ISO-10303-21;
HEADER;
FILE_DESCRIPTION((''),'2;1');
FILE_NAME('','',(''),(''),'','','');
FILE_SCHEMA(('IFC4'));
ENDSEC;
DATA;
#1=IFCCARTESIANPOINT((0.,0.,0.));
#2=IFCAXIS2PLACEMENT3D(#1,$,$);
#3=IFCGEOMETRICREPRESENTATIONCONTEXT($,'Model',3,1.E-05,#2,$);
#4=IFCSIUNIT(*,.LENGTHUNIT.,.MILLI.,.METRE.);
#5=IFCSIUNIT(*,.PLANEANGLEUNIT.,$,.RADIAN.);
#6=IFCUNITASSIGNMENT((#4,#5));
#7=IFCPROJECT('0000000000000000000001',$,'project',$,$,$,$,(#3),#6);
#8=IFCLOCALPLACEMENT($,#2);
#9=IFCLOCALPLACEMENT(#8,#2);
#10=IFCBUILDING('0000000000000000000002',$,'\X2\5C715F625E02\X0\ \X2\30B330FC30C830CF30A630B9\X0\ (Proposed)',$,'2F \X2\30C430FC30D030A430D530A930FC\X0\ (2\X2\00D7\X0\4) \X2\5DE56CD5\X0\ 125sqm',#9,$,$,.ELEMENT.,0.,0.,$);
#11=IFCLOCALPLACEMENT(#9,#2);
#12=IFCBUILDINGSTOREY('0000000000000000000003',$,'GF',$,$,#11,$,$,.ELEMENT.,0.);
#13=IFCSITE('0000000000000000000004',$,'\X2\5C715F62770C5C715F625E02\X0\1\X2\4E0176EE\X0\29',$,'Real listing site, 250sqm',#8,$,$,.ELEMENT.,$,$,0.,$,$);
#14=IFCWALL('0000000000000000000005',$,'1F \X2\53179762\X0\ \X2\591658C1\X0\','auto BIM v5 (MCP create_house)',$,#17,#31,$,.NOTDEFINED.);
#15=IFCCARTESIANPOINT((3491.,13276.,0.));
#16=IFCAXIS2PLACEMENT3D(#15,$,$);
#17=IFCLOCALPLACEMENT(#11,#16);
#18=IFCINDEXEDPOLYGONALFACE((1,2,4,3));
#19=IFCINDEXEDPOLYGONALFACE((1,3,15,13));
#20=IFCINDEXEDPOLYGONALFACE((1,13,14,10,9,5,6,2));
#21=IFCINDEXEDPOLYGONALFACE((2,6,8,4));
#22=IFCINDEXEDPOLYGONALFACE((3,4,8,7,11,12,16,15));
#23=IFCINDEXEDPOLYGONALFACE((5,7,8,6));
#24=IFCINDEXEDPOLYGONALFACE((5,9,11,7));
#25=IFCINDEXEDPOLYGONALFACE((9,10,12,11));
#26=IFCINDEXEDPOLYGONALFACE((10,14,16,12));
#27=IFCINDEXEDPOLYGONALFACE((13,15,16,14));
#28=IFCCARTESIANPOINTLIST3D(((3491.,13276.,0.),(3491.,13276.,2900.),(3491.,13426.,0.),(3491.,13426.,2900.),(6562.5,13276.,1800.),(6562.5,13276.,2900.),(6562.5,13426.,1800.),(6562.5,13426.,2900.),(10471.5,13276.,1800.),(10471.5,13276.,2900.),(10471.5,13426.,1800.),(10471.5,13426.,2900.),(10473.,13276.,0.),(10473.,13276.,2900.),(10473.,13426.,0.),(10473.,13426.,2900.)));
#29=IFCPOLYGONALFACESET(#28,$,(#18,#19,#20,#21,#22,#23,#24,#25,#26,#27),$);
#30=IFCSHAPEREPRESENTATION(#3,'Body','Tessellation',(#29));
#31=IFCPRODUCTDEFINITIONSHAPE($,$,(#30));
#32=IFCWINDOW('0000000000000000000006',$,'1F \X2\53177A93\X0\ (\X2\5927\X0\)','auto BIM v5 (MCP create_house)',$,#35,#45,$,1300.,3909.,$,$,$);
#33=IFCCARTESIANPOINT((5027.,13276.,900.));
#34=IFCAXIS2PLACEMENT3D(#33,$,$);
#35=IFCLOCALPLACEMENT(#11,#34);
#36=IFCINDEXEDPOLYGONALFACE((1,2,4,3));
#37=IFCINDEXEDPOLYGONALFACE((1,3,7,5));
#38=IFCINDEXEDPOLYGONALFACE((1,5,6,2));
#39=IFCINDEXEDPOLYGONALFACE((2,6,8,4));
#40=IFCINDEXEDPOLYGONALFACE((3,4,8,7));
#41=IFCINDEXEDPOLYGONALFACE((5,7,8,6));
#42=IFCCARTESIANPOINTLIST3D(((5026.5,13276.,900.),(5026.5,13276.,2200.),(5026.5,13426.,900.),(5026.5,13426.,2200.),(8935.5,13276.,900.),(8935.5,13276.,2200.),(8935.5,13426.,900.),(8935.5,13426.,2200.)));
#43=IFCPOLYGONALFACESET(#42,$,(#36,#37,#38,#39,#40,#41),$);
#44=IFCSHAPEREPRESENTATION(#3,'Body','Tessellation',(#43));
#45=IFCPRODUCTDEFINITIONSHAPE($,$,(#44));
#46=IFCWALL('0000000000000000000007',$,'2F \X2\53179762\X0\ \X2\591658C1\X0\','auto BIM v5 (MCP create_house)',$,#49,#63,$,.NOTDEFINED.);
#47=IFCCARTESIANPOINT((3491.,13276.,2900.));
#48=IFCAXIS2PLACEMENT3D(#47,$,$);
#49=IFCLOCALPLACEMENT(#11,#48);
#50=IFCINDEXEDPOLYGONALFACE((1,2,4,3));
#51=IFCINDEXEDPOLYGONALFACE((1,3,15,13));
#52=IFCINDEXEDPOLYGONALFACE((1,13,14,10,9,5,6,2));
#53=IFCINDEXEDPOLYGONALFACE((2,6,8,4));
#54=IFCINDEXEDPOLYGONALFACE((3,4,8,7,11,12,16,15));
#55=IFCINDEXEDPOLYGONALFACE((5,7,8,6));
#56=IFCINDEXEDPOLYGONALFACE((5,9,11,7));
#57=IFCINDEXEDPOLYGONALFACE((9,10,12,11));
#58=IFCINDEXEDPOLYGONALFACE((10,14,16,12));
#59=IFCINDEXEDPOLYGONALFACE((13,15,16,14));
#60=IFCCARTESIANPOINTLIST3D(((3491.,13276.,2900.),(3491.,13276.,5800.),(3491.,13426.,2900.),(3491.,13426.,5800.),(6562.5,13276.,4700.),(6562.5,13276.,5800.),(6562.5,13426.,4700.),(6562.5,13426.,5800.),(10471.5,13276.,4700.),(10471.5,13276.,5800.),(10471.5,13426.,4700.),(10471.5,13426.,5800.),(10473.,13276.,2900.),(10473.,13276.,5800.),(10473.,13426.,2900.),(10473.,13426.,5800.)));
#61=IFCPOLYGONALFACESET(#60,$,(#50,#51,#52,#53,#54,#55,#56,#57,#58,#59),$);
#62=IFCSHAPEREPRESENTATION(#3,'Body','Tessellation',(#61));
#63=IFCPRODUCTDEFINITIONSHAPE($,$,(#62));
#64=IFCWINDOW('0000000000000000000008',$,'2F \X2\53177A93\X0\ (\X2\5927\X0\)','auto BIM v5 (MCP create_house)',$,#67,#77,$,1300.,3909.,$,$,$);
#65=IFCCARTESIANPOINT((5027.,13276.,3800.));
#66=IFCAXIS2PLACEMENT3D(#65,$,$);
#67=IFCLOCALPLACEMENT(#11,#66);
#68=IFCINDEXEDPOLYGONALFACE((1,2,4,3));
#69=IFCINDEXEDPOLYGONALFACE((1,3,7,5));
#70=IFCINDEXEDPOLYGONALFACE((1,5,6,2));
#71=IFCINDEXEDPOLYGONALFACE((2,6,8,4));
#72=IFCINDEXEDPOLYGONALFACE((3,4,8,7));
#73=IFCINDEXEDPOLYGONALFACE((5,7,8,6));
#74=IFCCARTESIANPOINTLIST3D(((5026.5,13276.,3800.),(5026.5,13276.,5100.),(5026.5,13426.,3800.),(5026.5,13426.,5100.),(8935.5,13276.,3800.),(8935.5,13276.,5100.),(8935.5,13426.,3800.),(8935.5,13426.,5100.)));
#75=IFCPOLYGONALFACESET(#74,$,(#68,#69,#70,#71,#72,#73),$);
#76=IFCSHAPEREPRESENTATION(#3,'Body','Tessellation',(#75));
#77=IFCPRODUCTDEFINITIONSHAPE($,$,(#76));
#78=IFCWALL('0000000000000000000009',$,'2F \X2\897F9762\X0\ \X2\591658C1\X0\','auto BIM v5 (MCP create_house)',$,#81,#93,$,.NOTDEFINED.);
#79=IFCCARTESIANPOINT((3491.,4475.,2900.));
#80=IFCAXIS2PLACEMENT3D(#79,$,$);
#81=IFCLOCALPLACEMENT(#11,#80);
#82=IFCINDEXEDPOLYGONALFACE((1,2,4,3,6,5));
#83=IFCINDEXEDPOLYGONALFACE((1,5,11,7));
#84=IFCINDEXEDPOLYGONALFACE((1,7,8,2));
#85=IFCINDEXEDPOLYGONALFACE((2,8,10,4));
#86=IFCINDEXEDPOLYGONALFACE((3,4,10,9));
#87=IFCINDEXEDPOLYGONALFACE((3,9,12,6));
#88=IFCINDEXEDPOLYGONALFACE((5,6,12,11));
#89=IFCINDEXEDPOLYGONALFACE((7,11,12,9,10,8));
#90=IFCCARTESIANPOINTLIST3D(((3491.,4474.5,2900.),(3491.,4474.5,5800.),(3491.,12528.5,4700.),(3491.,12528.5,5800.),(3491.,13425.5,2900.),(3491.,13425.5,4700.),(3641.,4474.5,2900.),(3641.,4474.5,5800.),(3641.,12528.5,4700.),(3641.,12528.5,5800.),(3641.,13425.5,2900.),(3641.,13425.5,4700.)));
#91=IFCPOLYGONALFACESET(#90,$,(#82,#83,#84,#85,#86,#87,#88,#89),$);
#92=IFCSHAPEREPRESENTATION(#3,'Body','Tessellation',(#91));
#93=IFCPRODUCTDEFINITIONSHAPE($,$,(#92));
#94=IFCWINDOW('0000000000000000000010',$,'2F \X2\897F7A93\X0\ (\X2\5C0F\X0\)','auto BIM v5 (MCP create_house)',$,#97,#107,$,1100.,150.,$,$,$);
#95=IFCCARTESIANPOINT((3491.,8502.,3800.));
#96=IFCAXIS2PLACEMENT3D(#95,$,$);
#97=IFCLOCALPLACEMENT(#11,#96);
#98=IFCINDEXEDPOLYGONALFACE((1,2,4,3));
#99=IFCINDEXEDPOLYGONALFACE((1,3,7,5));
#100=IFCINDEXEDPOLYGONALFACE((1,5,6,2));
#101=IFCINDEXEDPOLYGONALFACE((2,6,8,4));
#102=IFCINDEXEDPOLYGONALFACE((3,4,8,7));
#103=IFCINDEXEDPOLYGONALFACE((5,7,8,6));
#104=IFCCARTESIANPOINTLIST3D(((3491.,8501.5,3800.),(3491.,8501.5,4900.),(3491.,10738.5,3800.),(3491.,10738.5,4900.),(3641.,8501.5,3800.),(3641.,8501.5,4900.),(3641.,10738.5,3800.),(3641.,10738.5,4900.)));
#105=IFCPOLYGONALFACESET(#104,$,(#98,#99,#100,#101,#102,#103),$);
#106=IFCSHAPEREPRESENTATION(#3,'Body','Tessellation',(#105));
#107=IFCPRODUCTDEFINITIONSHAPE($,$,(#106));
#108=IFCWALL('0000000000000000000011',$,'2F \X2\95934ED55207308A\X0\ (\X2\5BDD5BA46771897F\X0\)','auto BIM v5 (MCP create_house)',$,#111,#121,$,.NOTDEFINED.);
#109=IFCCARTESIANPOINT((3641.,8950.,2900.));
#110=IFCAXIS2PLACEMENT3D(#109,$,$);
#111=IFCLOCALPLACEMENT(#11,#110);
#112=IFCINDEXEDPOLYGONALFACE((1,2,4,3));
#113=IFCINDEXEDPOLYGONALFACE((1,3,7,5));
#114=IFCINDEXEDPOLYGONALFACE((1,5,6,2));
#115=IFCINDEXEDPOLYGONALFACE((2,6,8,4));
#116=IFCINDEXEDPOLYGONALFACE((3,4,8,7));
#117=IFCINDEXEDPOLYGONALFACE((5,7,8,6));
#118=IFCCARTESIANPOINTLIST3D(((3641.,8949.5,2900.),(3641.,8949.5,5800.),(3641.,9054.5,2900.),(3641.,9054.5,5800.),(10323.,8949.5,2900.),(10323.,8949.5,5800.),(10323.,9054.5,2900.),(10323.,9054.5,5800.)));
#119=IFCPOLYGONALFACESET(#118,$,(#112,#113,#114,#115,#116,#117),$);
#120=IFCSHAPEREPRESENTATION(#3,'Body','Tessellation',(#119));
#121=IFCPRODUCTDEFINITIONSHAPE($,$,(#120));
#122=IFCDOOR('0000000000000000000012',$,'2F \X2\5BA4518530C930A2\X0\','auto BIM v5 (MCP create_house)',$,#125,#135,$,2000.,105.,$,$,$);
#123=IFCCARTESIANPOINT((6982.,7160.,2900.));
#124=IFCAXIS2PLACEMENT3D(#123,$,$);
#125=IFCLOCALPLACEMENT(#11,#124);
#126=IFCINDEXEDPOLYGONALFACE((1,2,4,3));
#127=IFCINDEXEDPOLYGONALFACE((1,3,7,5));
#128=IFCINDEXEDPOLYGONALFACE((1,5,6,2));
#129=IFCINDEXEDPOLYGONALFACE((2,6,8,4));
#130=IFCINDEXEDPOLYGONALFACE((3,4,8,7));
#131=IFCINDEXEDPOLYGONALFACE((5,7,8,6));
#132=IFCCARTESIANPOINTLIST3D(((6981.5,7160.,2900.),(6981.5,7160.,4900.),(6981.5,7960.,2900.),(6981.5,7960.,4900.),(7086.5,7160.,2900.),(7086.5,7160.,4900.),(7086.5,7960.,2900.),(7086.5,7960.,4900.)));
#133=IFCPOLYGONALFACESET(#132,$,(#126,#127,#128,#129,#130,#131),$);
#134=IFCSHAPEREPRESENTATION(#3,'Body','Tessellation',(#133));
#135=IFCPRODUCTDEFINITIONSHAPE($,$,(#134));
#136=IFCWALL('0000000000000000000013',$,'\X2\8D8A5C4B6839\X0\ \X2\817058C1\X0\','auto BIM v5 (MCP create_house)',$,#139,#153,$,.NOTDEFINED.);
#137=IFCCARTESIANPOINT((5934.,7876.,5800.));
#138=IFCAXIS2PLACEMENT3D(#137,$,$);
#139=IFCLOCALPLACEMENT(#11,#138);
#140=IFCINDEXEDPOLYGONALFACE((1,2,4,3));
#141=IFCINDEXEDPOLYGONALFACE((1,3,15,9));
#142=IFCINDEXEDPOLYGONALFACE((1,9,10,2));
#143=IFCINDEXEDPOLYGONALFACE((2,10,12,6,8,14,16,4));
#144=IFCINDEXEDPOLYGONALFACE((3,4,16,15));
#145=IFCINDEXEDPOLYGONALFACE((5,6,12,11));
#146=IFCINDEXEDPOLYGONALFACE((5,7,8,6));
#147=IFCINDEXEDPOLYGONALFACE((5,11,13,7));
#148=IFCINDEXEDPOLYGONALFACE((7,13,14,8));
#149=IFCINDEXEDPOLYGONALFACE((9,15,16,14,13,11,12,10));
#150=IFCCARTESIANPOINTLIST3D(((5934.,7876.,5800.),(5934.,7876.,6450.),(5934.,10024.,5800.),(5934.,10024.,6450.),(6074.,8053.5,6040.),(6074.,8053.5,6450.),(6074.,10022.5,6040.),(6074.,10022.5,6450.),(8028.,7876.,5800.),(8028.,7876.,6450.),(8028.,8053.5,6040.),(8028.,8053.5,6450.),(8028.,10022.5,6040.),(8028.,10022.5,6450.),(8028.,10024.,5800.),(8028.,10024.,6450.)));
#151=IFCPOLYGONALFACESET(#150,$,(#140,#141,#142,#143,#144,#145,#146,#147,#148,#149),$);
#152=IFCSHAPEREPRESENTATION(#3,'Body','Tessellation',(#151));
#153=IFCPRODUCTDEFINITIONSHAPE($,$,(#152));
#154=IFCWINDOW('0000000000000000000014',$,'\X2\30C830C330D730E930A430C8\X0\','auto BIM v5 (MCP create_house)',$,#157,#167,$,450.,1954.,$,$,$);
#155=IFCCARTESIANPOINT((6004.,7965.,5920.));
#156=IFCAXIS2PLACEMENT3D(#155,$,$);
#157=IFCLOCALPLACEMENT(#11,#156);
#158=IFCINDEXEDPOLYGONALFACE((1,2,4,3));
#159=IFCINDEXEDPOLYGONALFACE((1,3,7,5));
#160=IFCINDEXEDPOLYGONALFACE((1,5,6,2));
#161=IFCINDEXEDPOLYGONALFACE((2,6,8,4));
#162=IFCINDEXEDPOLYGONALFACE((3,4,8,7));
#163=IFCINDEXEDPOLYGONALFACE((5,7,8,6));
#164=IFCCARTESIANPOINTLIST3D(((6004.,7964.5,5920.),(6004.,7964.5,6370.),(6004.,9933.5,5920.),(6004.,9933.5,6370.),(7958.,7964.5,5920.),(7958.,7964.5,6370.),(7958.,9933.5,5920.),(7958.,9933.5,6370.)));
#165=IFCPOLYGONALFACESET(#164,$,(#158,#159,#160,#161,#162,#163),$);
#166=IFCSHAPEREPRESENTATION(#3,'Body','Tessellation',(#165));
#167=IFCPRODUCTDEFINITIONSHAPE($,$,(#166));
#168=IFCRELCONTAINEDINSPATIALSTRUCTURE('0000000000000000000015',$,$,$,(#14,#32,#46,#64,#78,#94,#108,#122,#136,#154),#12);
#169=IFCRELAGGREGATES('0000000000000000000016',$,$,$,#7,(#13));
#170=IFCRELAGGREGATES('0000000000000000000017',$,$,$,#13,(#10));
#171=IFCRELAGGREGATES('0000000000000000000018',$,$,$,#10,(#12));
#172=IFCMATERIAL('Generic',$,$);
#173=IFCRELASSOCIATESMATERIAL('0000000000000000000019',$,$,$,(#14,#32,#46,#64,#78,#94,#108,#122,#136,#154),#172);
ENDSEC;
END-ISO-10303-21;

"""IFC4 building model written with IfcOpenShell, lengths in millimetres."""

from ifc_helpers import new_model, si_unit, frame, frame_2d, origin, place, context, project, spatial, rectangle, extrude, material, element, fill, save


model = new_model("IFC4")

# Units and contexts
model_context = context("Model", 3, precision=1e-05, world=origin())
ifc_project = project(units=[si_unit("LENGTHUNIT", "METRE", prefix="MILLI"), si_unit("PLANEANGLEUNIT", "RADIAN")], contexts=[model_context])

# Site, building, storey
site_placement = place(None, origin())
site = spatial("IfcSite", under=ifc_project, at=site_placement, Name="山形県山形市1丁目29", ObjectType="Real listing site, 250sqm", CompositionType="ELEMENT", RefElevation=0.0)
building_placement = place(site_placement, origin())
building = spatial("IfcBuilding", under=site, at=building_placement, Name="山形市 コートハウス (Proposed)", ObjectType="2F ツーバイフォー (2×4) 工法 125sqm", CompositionType="ELEMENT", ElevationOfRefHeight=0.0, ElevationOfTerrain=0.0)
storey_placement = place(building_placement, origin())
storey = spatial("IfcBuildingStorey", under=building, at=storey_placement, Name="GF", CompositionType="ELEMENT", Elevation=0.0)

# Wall, opening, window
ifc_material = material(Name="Generic")
wall_1_placement = place(storey_placement, frame((3491.0, 13276.0, 0.0)))
wall_1 = element("IfcWall", 1, at=wall_1_placement, inside=storey, material=ifc_material, Name="1F 北面 外壁", Description="auto BIM v5 (MCP create_house)", PredefinedType="NOTDEFINED", context=model_context, shape_type="SweptSolid", body=[
    extrude(rectangle(XDim=6982.0, YDim=150.0, at=frame_2d((3491.0, 75.0))), frame((3491.0, 13276.0, 0.0)), (0.0, 0.0, 1.0), 2900.0),
])
opening_1_placement = place(storey_placement, frame((5027.0, 13276.0, 900.0)))
opening_1 = element("IfcOpeningElement", 2, at=opening_1_placement, cuts=wall_1, PredefinedType="NOTDEFINED", context=model_context, shape_type="SweptSolid", body=[
    extrude(rectangle(XDim=3909.0, YDim=150.0, at=frame_2d((1954.0, 75.0))), frame((5027.0, 13276.0, 900.0)), (0.0, 0.0, 1.0), 1300.0),
])
window_1_placement = place(storey_placement, frame((5027.0, 13276.0, 900.0)))
window_1 = element("IfcWindow", 3, at=window_1_placement, inside=storey, material=ifc_material, Name="1F 北窓 (大)", Description="auto BIM v5 (MCP create_house)", OverallHeight=1300.0, OverallWidth=3909.0, context=model_context, shape_type="SweptSolid", body=[
    extrude(rectangle(XDim=3909.0, YDim=150.0, at=frame_2d((1954.0, 75.0))), frame((5027.0, 13276.0, 900.0)), (0.0, 0.0, 1.0), 1300.0),
])
fill(opening_1, window_1)

# Walls, openings, windows
wall_2_placement = place(storey_placement, frame((3491.0, 13276.0, 2900.0)))
wall_2 = element("IfcWall", 4, at=wall_2_placement, inside=storey, material=ifc_material, Name="2F 北面 外壁", Description="auto BIM v5 (MCP create_house)", PredefinedType="NOTDEFINED", context=model_context, shape_type="SweptSolid", body=[
    extrude(rectangle(XDim=6982.0, YDim=150.0, at=frame_2d((3491.0, 75.0))), frame((3491.0, 13276.0, 2900.0)), (0.0, 0.0, 1.0), 2900.0),
])
opening_2_placement = place(storey_placement, frame((5027.0, 13276.0, 3800.0)))
opening_2 = element("IfcOpeningElement", 5, at=opening_2_placement, cuts=wall_2, PredefinedType="NOTDEFINED", context=model_context, shape_type="SweptSolid", body=[
    extrude(rectangle(XDim=3909.0, YDim=150.0, at=frame_2d((1954.0, 75.0))), frame((5027.0, 13276.0, 3800.0)), (0.0, 0.0, 1.0), 1300.0),
])
window_2_placement = place(storey_placement, frame((5027.0, 13276.0, 3800.0)))
window_2 = element("IfcWindow", 6, at=window_2_placement, inside=storey, material=ifc_material, Name="2F 北窓 (大)", Description="auto BIM v5 (MCP create_house)", OverallHeight=1300.0, OverallWidth=3909.0, context=model_context, shape_type="SweptSolid", body=[
    extrude(rectangle(XDim=3909.0, YDim=150.0, at=frame_2d((1954.0, 75.0))), frame((5027.0, 13276.0, 3800.0)), (0.0, 0.0, 1.0), 1300.0),
])
fill(opening_2, window_2)
wall_3_placement = place(storey_placement, frame((3491.0, 4475.0, 2900.0)))
wall_3 = element("IfcWall", 7, at=wall_3_placement, inside=storey, material=ifc_material, Name="2F 西面 外壁", Description="auto BIM v5 (MCP create_house)", PredefinedType="NOTDEFINED", context=model_context, shape_type="SweptSolid", body=[
    extrude(rectangle(XDim=150.0, YDim=8951.0, at=frame_2d((75.0, 4475.0))), frame((3491.0, 4475.0, 2900.0)), (0.0, 0.0, 1.0), 2900.0),
])
opening_3_placement = place(storey_placement, frame((3491.0, 8502.0, 3800.0)))
opening_3 = element("IfcOpeningElement", 8, at=opening_3_placement, cuts=wall_3, PredefinedType="NOTDEFINED", context=model_context, shape_type="SweptSolid", body=[
    extrude(rectangle(XDim=150.0, YDim=2237.0, at=frame_2d((75.0, 1118.0))), frame((3491.0, 8502.0, 3800.0)), (0.0, 0.0, 1.0), 1100.0),
])
window_3_placement = place(storey_placement, frame((3491.0, 8502.0, 3800.0)))
window_3 = element("IfcWindow", 9, at=window_3_placement, inside=storey, material=ifc_material, Name="2F 西窓 (小)", Description="auto BIM v5 (MCP create_house)", OverallHeight=1100.0, OverallWidth=150.0, context=model_context, shape_type="SweptSolid", body=[
    extrude(rectangle(XDim=150.0, YDim=2237.0, at=frame_2d((75.0, 1118.0))), frame((3491.0, 8502.0, 3800.0)), (0.0, 0.0, 1.0), 1100.0),
])
fill(opening_3, window_3)

# Wall
wall_4_placement = place(storey_placement, frame((3641.0, 8950.0, 2900.0)))
element("IfcWall", 10, at=wall_4_placement, inside=storey, material=ifc_material, Name="2F 間仕切り (寝室東西)", Description="auto BIM v5 (MCP create_house)", PredefinedType="NOTDEFINED", context=model_context, shape_type="SweptSolid", body=[
    extrude(rectangle(XDim=6682.0, YDim=105.0, at=frame_2d((3341.0, 52.0))), frame((3641.0, 8950.0, 2900.0)), (0.0, 0.0, 1.0), 2900.0),
])

# Door
door_placement = place(storey_placement, frame((6982.0, 7160.0, 2900.0)))
element("IfcDoor", 11, at=door_placement, inside=storey, material=ifc_material, Name="2F 室内ドア", Description="auto BIM v5 (MCP create_house)", OverallHeight=2000.0, OverallWidth=105.0, context=model_context, shape_type="SweptSolid", body=[
    extrude(rectangle(XDim=105.0, YDim=800.0, at=frame_2d((52.0, 400.0))), frame((6982.0, 7160.0, 2900.0)), (0.0, 0.0, 1.0), 2000.0),
])

# Wall, opening, window
wall_5_placement = place(storey_placement, frame((5934.0, 7876.0, 5800.0)))
wall_5 = element("IfcWall", 12, at=wall_5_placement, inside=storey, material=ifc_material, Name="越屋根 腰壁", Description="auto BIM v5 (MCP create_house)", PredefinedType="NOTDEFINED", context=model_context, shape_type="SweptSolid", body=[
    extrude(rectangle(XDim=2094.0, YDim=2148.0, at=frame_2d((1047.0, 1074.0))), frame((5934.0, 7876.0, 5800.0)), (0.0, 0.0, 1.0), 650.0),
])
opening_4_placement = place(storey_placement, frame((6004.0, 7965.0, 5920.0)))
opening_4 = element("IfcOpeningElement", 13, at=opening_4_placement, cuts=wall_5, PredefinedType="NOTDEFINED", context=model_context, shape_type="SweptSolid", body=[
    extrude(rectangle(XDim=1954.0, YDim=1969.0, at=frame_2d((977.0, 984.0))), frame((6004.0, 7965.0, 5920.0)), (0.0, 0.0, 1.0), 450.0),
])
window_4_placement = place(storey_placement, frame((6004.0, 7965.0, 5920.0)))
window_4 = element("IfcWindow", 14, at=window_4_placement, inside=storey, material=ifc_material, Name="トップライト", Description="auto BIM v5 (MCP create_house)", OverallHeight=450.0, OverallWidth=1954.0, context=model_context, shape_type="SweptSolid", body=[
    extrude(rectangle(XDim=1954.0, YDim=1969.0, at=frame_2d((977.0, 984.0))), frame((6004.0, 7965.0, 5920.0)), (0.0, 0.0, 1.0), 450.0),
])
fill(opening_4, window_4)

save(model, "model.ifc")
